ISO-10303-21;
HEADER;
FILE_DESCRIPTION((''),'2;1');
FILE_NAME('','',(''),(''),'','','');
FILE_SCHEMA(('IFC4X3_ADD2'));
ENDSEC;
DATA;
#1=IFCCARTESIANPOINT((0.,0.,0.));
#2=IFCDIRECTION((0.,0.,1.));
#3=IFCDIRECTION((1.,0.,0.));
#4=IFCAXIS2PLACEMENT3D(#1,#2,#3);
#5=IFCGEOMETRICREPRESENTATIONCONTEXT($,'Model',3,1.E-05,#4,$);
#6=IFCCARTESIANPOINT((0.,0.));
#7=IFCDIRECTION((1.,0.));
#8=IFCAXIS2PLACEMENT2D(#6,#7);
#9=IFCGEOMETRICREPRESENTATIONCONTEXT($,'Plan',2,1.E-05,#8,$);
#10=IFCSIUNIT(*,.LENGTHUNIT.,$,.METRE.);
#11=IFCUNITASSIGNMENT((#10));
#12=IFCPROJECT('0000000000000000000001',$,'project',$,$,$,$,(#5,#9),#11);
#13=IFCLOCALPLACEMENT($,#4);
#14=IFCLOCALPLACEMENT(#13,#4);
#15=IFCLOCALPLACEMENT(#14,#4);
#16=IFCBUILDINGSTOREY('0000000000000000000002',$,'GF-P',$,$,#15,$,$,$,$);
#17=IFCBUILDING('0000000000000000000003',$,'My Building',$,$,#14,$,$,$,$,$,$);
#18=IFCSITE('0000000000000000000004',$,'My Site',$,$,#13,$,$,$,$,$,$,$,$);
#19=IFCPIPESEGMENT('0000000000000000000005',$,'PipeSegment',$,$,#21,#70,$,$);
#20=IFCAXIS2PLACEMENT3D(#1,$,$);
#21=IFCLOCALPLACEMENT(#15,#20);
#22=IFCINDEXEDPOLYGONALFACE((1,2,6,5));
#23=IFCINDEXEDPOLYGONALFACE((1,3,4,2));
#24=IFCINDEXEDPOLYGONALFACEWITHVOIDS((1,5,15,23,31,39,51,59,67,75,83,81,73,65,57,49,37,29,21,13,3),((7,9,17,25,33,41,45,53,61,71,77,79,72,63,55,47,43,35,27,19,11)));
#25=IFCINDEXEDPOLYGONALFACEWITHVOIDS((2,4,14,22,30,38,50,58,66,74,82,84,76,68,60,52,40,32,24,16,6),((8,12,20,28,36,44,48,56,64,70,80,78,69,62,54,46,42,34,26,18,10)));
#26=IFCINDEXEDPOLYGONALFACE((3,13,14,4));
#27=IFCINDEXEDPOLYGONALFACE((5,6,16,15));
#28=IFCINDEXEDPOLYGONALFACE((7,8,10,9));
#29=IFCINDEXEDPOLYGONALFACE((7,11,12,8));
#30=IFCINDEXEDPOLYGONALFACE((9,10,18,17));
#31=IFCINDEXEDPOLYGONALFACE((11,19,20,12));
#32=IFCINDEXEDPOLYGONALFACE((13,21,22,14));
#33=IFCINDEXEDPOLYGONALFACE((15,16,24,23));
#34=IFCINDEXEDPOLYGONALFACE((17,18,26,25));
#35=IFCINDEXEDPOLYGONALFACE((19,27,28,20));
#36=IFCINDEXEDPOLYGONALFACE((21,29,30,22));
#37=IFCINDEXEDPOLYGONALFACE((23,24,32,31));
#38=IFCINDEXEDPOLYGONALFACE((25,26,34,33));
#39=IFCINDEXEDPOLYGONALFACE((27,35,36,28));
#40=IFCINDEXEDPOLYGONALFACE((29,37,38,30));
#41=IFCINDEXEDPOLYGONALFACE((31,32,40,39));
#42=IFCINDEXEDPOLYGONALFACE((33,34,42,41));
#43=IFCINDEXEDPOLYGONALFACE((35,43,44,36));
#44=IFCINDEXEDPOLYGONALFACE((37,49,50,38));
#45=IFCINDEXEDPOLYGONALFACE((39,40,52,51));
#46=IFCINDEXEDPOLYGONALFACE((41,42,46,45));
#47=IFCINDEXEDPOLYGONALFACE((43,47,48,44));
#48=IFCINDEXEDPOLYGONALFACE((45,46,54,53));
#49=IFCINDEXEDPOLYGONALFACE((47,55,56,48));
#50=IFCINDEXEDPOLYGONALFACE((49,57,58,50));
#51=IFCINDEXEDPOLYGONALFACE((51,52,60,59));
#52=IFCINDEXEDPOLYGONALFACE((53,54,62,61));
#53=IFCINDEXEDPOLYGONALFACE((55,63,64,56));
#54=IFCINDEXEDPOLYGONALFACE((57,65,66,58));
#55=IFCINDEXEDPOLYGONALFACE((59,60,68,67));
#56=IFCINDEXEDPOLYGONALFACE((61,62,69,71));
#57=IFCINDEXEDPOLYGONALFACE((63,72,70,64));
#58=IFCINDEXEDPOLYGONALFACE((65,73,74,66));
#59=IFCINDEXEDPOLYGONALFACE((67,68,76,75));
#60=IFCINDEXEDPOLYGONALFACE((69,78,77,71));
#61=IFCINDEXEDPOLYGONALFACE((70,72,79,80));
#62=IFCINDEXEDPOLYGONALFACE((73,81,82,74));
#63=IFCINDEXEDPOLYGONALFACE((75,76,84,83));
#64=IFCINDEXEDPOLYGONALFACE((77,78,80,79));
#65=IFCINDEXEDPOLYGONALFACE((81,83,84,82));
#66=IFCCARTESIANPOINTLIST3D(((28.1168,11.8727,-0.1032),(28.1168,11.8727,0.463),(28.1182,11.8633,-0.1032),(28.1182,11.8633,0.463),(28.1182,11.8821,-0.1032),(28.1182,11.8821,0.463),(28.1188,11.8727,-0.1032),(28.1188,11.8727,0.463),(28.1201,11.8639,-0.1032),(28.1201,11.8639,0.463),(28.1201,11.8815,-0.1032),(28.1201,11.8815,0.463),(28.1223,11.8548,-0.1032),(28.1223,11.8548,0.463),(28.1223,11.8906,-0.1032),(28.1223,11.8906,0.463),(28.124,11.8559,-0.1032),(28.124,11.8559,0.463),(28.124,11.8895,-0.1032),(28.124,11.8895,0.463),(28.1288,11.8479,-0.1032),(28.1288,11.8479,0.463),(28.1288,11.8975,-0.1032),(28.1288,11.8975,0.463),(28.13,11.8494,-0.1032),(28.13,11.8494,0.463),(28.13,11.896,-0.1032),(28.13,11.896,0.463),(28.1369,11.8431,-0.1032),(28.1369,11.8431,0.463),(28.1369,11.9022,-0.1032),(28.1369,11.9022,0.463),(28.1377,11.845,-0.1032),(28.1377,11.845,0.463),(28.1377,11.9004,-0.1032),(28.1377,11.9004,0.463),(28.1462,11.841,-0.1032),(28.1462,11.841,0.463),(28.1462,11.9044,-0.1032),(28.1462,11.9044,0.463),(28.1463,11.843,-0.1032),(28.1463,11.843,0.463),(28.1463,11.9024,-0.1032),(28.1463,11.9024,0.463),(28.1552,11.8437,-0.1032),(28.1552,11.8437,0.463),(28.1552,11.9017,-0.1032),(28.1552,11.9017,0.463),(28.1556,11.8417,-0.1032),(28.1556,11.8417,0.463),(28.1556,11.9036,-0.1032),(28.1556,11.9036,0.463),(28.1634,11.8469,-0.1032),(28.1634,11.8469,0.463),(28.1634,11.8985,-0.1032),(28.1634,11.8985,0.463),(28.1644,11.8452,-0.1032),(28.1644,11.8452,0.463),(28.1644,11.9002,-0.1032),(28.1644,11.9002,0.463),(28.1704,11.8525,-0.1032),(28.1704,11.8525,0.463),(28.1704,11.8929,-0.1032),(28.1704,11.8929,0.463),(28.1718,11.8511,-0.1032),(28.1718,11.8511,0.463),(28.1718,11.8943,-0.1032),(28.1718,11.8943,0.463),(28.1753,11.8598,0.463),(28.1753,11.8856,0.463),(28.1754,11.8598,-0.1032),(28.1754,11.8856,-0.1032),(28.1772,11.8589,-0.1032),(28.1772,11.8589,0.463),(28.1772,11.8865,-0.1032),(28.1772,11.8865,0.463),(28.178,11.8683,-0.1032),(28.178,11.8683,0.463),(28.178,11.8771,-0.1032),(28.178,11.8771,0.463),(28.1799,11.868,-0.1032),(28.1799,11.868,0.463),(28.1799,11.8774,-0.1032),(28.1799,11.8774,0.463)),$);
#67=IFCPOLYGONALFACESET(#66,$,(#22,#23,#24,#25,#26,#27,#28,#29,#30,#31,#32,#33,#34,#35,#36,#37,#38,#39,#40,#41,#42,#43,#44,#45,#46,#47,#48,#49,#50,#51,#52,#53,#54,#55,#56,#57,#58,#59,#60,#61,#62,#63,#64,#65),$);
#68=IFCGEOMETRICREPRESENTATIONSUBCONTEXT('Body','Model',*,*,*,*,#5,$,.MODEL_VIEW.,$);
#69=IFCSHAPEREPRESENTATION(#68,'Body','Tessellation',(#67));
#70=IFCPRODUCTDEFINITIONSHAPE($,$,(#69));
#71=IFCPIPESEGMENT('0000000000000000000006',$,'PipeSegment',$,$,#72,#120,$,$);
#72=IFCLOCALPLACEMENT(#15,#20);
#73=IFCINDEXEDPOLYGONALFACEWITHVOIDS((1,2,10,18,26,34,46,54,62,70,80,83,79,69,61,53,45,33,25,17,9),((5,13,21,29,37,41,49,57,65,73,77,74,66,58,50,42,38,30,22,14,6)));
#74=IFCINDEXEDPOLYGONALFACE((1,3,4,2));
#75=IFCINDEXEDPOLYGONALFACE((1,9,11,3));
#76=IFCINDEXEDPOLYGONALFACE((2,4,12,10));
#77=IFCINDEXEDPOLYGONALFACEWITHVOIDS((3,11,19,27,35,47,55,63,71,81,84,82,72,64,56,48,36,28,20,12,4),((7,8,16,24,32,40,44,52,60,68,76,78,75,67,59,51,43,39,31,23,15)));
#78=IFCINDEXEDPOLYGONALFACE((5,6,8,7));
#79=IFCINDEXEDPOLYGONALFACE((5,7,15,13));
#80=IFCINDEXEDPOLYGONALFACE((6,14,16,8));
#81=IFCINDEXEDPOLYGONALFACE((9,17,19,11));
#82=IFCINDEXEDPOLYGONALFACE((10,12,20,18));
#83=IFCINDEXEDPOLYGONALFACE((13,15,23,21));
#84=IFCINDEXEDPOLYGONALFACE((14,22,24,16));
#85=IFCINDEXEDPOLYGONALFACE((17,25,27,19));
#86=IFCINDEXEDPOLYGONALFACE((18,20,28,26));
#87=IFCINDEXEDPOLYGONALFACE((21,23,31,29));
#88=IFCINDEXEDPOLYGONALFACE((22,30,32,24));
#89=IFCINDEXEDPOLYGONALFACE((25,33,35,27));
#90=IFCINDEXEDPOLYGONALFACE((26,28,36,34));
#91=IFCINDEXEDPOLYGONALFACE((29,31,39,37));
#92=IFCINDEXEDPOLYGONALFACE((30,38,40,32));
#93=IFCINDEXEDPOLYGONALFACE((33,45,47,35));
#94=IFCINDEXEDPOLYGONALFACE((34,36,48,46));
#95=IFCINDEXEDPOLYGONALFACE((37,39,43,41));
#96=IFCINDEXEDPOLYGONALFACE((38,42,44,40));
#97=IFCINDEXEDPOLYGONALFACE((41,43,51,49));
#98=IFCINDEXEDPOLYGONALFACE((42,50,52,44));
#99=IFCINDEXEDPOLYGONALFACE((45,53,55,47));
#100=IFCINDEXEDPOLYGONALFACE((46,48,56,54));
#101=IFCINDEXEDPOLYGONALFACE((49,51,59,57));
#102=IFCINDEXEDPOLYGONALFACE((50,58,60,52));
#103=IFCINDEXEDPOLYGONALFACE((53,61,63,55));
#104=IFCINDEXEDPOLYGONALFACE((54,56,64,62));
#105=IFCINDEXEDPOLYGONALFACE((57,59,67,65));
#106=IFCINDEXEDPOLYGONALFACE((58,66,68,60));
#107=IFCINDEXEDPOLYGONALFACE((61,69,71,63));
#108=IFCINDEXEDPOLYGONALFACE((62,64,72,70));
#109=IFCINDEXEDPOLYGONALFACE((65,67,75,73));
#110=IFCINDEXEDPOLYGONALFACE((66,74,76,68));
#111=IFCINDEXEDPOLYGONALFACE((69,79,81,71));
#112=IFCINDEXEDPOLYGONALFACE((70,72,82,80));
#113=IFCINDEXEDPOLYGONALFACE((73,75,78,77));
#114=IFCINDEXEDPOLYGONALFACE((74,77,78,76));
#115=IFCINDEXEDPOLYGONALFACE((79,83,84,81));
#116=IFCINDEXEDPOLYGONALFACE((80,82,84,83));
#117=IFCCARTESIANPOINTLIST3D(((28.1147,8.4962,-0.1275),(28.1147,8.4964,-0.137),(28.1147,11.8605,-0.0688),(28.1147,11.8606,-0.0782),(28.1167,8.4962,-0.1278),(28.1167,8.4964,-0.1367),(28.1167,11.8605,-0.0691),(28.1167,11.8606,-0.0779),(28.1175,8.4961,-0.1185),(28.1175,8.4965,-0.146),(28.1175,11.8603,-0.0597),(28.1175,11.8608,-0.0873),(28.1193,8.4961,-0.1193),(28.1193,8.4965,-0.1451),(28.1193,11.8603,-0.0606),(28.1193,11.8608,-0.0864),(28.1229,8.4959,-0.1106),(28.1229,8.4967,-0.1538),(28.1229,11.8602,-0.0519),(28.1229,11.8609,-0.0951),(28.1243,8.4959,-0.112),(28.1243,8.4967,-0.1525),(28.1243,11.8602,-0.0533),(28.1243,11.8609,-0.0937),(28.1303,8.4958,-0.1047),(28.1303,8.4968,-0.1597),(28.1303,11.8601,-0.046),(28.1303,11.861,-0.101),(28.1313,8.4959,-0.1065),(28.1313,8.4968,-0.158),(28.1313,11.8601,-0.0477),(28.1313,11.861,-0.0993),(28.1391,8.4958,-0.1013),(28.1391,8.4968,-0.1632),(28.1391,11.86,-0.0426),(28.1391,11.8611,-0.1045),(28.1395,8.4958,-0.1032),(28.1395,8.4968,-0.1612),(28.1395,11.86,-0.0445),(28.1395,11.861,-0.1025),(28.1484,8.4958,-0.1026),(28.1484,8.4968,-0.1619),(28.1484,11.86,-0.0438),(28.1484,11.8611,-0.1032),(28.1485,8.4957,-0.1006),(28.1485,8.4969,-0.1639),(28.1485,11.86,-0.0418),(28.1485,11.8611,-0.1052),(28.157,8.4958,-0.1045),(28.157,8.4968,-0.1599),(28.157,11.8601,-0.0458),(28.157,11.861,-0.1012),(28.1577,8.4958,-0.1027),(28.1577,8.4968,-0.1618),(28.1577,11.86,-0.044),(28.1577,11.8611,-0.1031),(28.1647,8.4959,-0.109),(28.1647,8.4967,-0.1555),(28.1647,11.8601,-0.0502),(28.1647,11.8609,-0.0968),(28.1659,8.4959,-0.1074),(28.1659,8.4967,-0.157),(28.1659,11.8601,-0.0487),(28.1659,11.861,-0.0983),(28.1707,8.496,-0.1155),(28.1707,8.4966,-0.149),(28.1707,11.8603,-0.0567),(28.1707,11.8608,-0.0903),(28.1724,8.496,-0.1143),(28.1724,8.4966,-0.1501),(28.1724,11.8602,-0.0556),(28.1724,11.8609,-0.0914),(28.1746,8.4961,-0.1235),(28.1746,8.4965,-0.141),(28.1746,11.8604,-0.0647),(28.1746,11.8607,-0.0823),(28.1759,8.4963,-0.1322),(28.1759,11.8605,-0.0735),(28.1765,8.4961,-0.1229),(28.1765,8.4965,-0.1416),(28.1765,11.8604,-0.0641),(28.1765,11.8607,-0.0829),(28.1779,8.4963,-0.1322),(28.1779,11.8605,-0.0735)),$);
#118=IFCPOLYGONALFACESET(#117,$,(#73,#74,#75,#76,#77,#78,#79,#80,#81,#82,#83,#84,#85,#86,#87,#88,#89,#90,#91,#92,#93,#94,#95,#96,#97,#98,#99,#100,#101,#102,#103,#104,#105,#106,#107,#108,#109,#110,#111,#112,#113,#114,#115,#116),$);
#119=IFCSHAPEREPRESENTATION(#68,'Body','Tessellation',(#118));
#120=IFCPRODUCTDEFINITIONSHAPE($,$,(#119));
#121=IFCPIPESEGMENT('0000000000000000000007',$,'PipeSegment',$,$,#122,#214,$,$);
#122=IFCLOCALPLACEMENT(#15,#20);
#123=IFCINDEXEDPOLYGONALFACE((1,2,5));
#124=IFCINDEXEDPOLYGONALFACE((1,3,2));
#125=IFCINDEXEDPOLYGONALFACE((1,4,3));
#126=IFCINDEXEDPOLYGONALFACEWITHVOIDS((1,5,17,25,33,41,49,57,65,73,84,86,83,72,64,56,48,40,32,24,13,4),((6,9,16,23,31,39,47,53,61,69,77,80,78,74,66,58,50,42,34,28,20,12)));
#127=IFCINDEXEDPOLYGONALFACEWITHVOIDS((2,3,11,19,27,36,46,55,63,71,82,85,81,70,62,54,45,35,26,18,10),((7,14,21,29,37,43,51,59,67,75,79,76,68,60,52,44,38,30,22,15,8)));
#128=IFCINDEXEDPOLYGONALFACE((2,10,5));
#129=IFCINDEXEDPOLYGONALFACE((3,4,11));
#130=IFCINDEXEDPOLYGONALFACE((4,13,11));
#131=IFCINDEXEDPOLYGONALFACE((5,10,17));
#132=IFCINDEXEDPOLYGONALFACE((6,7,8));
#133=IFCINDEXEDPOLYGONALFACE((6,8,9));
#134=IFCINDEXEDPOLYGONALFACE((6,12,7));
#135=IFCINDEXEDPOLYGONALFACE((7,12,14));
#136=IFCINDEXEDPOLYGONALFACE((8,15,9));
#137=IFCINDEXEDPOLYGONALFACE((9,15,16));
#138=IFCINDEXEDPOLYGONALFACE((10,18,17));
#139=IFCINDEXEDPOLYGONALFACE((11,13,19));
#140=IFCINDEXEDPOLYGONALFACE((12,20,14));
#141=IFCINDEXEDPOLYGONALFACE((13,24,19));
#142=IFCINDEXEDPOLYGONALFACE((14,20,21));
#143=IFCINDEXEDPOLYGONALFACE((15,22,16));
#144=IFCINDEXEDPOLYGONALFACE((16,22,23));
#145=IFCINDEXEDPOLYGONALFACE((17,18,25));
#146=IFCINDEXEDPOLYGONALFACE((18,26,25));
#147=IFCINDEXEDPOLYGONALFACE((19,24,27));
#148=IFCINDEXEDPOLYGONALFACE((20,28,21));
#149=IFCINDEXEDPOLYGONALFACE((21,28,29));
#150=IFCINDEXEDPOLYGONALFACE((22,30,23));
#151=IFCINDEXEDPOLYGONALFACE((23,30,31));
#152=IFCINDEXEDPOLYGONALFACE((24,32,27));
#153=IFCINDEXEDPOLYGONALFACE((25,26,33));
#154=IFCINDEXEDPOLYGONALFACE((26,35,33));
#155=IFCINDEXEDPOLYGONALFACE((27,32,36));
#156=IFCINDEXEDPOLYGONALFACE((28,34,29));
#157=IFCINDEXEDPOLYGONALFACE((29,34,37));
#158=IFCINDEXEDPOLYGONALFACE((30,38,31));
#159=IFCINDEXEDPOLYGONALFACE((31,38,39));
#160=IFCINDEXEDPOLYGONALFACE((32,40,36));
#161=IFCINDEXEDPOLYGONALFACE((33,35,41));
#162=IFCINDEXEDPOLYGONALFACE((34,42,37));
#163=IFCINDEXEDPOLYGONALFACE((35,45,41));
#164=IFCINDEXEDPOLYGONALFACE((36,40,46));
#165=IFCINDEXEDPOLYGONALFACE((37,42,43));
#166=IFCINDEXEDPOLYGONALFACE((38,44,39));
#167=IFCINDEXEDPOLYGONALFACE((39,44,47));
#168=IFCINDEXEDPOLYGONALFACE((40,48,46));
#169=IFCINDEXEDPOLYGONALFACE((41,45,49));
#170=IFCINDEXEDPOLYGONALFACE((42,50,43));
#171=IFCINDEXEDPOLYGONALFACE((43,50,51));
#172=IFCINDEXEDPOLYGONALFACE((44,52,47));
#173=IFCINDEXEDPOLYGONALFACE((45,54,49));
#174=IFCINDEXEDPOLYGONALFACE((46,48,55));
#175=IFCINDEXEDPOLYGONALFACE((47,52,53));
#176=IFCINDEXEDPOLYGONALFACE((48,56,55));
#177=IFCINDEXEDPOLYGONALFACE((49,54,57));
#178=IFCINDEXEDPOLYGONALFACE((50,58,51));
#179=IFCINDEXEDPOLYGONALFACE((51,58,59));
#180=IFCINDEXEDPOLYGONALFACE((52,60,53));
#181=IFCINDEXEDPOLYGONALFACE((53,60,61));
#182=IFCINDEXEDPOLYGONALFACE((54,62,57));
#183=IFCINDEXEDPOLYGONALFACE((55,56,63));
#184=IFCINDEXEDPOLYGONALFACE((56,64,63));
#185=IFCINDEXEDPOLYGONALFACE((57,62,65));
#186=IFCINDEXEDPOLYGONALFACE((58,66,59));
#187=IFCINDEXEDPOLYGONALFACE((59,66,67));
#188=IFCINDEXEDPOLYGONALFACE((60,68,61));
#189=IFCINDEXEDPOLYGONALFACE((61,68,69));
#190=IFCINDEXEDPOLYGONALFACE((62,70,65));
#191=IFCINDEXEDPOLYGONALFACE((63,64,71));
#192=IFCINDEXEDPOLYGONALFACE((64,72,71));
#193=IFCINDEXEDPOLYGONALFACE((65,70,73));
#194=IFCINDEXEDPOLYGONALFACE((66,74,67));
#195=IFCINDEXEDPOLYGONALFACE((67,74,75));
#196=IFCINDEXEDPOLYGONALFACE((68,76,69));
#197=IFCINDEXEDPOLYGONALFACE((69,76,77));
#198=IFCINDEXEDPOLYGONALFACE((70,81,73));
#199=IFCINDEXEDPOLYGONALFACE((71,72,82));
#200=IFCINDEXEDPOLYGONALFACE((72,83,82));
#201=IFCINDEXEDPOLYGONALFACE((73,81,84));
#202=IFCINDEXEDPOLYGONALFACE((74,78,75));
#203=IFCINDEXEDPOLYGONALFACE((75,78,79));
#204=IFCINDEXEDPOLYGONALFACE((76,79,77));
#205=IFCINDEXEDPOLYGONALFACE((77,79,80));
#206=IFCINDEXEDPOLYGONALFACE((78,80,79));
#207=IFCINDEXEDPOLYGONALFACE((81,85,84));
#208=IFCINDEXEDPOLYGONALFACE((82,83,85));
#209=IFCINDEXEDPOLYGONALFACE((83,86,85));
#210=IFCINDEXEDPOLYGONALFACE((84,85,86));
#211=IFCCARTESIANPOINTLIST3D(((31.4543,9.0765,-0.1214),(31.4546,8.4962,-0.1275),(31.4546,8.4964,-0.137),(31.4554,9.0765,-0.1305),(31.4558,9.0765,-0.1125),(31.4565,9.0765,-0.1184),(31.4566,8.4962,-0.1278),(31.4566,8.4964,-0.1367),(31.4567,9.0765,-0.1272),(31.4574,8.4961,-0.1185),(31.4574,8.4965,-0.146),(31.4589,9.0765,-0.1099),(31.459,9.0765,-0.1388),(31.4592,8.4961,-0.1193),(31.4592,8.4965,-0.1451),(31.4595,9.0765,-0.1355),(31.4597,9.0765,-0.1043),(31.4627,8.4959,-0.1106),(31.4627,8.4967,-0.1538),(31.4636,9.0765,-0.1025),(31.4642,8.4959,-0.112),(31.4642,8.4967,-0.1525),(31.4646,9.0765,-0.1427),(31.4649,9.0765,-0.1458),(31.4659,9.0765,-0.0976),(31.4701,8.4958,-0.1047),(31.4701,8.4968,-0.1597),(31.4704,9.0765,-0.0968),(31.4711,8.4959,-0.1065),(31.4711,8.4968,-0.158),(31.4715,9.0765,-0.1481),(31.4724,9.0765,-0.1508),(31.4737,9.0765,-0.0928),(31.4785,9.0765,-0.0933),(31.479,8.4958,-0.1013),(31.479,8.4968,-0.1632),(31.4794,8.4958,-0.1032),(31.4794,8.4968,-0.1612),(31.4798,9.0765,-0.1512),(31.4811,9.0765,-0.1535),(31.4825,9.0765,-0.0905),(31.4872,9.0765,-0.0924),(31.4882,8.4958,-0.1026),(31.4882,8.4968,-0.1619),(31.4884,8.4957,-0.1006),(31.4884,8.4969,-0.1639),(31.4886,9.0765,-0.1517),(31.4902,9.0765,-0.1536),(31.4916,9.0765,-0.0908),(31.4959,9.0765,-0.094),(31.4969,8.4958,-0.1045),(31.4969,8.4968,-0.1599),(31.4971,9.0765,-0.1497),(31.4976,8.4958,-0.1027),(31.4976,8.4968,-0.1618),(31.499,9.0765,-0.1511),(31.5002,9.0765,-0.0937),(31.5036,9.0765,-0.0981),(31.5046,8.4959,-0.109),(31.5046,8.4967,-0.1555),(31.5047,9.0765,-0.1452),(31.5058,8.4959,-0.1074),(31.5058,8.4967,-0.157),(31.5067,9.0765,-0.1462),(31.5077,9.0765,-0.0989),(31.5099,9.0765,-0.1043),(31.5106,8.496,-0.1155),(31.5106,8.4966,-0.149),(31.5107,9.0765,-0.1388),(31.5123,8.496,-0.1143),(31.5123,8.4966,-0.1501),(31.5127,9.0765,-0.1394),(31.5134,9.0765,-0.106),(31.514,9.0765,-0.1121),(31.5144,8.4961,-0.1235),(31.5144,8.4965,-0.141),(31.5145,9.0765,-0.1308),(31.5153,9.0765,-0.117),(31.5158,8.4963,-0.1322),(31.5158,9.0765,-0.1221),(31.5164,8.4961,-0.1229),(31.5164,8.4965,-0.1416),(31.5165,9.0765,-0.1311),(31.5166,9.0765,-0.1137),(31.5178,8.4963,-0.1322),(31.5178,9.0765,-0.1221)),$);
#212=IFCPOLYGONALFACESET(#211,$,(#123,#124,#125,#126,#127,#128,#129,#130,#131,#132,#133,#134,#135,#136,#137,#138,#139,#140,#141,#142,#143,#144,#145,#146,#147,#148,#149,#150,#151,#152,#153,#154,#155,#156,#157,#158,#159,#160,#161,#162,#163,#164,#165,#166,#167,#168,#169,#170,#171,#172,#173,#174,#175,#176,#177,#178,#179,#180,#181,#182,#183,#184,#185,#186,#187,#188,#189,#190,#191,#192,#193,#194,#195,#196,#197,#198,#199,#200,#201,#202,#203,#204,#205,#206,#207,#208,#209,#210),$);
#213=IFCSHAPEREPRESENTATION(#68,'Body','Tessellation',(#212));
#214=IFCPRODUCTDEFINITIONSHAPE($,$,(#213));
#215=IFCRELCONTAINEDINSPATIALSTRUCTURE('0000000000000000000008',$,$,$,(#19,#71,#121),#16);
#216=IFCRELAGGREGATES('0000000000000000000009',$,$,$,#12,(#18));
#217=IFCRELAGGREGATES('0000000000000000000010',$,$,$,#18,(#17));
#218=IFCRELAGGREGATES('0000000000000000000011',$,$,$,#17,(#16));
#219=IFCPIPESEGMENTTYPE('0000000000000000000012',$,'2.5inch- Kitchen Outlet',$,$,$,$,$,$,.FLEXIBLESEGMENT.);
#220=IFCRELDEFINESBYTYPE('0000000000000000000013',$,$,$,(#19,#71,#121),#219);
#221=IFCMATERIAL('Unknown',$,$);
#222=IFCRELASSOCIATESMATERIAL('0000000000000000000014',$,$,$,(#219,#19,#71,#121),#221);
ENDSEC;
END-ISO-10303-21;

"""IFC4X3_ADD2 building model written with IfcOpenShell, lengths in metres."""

from ifc_helpers import new_model, si_unit, frame, origin_with_axes, origin_2d_with_axis, place, context, subcontext, project, spatial, hollow_circle, extrude, clip, halfspace, material, material_profile, profile_set, profile_usage, type_object, element, save


model = new_model("IFC4X3_ADD2")

# Units and contexts
model_context = context("Model", 3, precision=1e-05, world=origin_with_axes())
plan_context = context("Plan", 2, precision=1e-05, world=origin_2d_with_axis())
body_context = subcontext(model_context, "Body", "Model", "MODEL_VIEW")
ifc_project = project(units=[si_unit("LENGTHUNIT", "METRE")], contexts=[model_context, plan_context])

# Site, building, storey
site_placement = place(None, origin_with_axes())
site = spatial("IfcSite", under=ifc_project, at=site_placement, Name="My Site")
building_placement = place(site_placement, origin_with_axes())
building = spatial("IfcBuilding", under=site, at=building_placement, Name="My Building")
storey_placement = place(building_placement, origin_with_axes())
storey = spatial("IfcBuildingStorey", under=building, at=storey_placement, Name="GF-P")

# Pipe segments
ifc_material_1 = material(Name="Unknown")
ifc_material_profile_1 = material_profile(ifc_material_1, hollow_circle(Radius=0.0318, WallThickness=0.002))
ifc_profile_set_1 = profile_set([ifc_material_profile_1], Name="kitchenwater")
pipe_segment_type_1 = type_object("IfcPipeSegmentType", Name="2.5inch- Kitchen Outlet", PredefinedType="FLEXIBLESEGMENT", material=ifc_profile_set_1)
ifc_profile_usage_1 = profile_usage(ifc_profile_set_1)
pipe_segment_1_placement = place(storey_placement, frame((28.1485, 11.8727, -0.1032), z_axis=(0.0, 0.0, 1.0), x_axis=(-1.0, 0.0, 0.0)))
element("IfcPipeSegment", 1, at=pipe_segment_1_placement, inside=storey, type_object=pipe_segment_type_1, material=ifc_profile_usage_1, Name="PipeSegment", context=body_context, shape_type="SweptSolid", body=[
    extrude(hollow_circle(Radius=0.0318, WallThickness=0.002), origin_with_axes(), (0.0, 0.0, 1.0), 0.5662),
])
ifc_profile_usage_2 = profile_usage(ifc_profile_set_1)
pipe_segment_2_placement = place(storey_placement, frame((28.1461, 11.8605, -0.0735), z_axis=(0.0, -0.999848, -0.017452), x_axis=(1.0, 0.0, 0.0)))
element("IfcPipeSegment", 2, at=pipe_segment_2_placement, inside=storey, type_object=pipe_segment_type_1, material=ifc_profile_usage_2, Name="PipeSegment", context=body_context, shape_type="SweptSolid", body=[
    extrude(hollow_circle(Radius=0.0318, WallThickness=0.002), origin_with_axes(), (0.0, 0.0, 1.0), 3.3648),
])
ifc_profile_usage_3 = profile_usage(ifc_profile_set_1)
pipe_segment_3_placement = place(storey_placement, frame((31.486, 9.14, -0.121), z_axis=(0.0, -0.999848, -0.017452), x_axis=(1.0, 0.0, 0.0)))
element("IfcPipeSegment", 3, at=pipe_segment_3_placement, inside=storey, type_object=pipe_segment_type_1, material=ifc_profile_usage_3, Name="PipeSegment", context=body_context, shape_type="Clipping", body=[
    clip(extrude(hollow_circle(Radius=0.0318, WallThickness=0.002), origin_with_axes(), (0.0, 0.0, 1.0), 0.6438), halfspace(frame((0.0, -0.0946, 0.0652), z_axis=(0.0, -0.017452, -0.999848), x_axis=(-1.0, 0.000005, 0.0)), False)),
])

save(model, "model.ifc")
